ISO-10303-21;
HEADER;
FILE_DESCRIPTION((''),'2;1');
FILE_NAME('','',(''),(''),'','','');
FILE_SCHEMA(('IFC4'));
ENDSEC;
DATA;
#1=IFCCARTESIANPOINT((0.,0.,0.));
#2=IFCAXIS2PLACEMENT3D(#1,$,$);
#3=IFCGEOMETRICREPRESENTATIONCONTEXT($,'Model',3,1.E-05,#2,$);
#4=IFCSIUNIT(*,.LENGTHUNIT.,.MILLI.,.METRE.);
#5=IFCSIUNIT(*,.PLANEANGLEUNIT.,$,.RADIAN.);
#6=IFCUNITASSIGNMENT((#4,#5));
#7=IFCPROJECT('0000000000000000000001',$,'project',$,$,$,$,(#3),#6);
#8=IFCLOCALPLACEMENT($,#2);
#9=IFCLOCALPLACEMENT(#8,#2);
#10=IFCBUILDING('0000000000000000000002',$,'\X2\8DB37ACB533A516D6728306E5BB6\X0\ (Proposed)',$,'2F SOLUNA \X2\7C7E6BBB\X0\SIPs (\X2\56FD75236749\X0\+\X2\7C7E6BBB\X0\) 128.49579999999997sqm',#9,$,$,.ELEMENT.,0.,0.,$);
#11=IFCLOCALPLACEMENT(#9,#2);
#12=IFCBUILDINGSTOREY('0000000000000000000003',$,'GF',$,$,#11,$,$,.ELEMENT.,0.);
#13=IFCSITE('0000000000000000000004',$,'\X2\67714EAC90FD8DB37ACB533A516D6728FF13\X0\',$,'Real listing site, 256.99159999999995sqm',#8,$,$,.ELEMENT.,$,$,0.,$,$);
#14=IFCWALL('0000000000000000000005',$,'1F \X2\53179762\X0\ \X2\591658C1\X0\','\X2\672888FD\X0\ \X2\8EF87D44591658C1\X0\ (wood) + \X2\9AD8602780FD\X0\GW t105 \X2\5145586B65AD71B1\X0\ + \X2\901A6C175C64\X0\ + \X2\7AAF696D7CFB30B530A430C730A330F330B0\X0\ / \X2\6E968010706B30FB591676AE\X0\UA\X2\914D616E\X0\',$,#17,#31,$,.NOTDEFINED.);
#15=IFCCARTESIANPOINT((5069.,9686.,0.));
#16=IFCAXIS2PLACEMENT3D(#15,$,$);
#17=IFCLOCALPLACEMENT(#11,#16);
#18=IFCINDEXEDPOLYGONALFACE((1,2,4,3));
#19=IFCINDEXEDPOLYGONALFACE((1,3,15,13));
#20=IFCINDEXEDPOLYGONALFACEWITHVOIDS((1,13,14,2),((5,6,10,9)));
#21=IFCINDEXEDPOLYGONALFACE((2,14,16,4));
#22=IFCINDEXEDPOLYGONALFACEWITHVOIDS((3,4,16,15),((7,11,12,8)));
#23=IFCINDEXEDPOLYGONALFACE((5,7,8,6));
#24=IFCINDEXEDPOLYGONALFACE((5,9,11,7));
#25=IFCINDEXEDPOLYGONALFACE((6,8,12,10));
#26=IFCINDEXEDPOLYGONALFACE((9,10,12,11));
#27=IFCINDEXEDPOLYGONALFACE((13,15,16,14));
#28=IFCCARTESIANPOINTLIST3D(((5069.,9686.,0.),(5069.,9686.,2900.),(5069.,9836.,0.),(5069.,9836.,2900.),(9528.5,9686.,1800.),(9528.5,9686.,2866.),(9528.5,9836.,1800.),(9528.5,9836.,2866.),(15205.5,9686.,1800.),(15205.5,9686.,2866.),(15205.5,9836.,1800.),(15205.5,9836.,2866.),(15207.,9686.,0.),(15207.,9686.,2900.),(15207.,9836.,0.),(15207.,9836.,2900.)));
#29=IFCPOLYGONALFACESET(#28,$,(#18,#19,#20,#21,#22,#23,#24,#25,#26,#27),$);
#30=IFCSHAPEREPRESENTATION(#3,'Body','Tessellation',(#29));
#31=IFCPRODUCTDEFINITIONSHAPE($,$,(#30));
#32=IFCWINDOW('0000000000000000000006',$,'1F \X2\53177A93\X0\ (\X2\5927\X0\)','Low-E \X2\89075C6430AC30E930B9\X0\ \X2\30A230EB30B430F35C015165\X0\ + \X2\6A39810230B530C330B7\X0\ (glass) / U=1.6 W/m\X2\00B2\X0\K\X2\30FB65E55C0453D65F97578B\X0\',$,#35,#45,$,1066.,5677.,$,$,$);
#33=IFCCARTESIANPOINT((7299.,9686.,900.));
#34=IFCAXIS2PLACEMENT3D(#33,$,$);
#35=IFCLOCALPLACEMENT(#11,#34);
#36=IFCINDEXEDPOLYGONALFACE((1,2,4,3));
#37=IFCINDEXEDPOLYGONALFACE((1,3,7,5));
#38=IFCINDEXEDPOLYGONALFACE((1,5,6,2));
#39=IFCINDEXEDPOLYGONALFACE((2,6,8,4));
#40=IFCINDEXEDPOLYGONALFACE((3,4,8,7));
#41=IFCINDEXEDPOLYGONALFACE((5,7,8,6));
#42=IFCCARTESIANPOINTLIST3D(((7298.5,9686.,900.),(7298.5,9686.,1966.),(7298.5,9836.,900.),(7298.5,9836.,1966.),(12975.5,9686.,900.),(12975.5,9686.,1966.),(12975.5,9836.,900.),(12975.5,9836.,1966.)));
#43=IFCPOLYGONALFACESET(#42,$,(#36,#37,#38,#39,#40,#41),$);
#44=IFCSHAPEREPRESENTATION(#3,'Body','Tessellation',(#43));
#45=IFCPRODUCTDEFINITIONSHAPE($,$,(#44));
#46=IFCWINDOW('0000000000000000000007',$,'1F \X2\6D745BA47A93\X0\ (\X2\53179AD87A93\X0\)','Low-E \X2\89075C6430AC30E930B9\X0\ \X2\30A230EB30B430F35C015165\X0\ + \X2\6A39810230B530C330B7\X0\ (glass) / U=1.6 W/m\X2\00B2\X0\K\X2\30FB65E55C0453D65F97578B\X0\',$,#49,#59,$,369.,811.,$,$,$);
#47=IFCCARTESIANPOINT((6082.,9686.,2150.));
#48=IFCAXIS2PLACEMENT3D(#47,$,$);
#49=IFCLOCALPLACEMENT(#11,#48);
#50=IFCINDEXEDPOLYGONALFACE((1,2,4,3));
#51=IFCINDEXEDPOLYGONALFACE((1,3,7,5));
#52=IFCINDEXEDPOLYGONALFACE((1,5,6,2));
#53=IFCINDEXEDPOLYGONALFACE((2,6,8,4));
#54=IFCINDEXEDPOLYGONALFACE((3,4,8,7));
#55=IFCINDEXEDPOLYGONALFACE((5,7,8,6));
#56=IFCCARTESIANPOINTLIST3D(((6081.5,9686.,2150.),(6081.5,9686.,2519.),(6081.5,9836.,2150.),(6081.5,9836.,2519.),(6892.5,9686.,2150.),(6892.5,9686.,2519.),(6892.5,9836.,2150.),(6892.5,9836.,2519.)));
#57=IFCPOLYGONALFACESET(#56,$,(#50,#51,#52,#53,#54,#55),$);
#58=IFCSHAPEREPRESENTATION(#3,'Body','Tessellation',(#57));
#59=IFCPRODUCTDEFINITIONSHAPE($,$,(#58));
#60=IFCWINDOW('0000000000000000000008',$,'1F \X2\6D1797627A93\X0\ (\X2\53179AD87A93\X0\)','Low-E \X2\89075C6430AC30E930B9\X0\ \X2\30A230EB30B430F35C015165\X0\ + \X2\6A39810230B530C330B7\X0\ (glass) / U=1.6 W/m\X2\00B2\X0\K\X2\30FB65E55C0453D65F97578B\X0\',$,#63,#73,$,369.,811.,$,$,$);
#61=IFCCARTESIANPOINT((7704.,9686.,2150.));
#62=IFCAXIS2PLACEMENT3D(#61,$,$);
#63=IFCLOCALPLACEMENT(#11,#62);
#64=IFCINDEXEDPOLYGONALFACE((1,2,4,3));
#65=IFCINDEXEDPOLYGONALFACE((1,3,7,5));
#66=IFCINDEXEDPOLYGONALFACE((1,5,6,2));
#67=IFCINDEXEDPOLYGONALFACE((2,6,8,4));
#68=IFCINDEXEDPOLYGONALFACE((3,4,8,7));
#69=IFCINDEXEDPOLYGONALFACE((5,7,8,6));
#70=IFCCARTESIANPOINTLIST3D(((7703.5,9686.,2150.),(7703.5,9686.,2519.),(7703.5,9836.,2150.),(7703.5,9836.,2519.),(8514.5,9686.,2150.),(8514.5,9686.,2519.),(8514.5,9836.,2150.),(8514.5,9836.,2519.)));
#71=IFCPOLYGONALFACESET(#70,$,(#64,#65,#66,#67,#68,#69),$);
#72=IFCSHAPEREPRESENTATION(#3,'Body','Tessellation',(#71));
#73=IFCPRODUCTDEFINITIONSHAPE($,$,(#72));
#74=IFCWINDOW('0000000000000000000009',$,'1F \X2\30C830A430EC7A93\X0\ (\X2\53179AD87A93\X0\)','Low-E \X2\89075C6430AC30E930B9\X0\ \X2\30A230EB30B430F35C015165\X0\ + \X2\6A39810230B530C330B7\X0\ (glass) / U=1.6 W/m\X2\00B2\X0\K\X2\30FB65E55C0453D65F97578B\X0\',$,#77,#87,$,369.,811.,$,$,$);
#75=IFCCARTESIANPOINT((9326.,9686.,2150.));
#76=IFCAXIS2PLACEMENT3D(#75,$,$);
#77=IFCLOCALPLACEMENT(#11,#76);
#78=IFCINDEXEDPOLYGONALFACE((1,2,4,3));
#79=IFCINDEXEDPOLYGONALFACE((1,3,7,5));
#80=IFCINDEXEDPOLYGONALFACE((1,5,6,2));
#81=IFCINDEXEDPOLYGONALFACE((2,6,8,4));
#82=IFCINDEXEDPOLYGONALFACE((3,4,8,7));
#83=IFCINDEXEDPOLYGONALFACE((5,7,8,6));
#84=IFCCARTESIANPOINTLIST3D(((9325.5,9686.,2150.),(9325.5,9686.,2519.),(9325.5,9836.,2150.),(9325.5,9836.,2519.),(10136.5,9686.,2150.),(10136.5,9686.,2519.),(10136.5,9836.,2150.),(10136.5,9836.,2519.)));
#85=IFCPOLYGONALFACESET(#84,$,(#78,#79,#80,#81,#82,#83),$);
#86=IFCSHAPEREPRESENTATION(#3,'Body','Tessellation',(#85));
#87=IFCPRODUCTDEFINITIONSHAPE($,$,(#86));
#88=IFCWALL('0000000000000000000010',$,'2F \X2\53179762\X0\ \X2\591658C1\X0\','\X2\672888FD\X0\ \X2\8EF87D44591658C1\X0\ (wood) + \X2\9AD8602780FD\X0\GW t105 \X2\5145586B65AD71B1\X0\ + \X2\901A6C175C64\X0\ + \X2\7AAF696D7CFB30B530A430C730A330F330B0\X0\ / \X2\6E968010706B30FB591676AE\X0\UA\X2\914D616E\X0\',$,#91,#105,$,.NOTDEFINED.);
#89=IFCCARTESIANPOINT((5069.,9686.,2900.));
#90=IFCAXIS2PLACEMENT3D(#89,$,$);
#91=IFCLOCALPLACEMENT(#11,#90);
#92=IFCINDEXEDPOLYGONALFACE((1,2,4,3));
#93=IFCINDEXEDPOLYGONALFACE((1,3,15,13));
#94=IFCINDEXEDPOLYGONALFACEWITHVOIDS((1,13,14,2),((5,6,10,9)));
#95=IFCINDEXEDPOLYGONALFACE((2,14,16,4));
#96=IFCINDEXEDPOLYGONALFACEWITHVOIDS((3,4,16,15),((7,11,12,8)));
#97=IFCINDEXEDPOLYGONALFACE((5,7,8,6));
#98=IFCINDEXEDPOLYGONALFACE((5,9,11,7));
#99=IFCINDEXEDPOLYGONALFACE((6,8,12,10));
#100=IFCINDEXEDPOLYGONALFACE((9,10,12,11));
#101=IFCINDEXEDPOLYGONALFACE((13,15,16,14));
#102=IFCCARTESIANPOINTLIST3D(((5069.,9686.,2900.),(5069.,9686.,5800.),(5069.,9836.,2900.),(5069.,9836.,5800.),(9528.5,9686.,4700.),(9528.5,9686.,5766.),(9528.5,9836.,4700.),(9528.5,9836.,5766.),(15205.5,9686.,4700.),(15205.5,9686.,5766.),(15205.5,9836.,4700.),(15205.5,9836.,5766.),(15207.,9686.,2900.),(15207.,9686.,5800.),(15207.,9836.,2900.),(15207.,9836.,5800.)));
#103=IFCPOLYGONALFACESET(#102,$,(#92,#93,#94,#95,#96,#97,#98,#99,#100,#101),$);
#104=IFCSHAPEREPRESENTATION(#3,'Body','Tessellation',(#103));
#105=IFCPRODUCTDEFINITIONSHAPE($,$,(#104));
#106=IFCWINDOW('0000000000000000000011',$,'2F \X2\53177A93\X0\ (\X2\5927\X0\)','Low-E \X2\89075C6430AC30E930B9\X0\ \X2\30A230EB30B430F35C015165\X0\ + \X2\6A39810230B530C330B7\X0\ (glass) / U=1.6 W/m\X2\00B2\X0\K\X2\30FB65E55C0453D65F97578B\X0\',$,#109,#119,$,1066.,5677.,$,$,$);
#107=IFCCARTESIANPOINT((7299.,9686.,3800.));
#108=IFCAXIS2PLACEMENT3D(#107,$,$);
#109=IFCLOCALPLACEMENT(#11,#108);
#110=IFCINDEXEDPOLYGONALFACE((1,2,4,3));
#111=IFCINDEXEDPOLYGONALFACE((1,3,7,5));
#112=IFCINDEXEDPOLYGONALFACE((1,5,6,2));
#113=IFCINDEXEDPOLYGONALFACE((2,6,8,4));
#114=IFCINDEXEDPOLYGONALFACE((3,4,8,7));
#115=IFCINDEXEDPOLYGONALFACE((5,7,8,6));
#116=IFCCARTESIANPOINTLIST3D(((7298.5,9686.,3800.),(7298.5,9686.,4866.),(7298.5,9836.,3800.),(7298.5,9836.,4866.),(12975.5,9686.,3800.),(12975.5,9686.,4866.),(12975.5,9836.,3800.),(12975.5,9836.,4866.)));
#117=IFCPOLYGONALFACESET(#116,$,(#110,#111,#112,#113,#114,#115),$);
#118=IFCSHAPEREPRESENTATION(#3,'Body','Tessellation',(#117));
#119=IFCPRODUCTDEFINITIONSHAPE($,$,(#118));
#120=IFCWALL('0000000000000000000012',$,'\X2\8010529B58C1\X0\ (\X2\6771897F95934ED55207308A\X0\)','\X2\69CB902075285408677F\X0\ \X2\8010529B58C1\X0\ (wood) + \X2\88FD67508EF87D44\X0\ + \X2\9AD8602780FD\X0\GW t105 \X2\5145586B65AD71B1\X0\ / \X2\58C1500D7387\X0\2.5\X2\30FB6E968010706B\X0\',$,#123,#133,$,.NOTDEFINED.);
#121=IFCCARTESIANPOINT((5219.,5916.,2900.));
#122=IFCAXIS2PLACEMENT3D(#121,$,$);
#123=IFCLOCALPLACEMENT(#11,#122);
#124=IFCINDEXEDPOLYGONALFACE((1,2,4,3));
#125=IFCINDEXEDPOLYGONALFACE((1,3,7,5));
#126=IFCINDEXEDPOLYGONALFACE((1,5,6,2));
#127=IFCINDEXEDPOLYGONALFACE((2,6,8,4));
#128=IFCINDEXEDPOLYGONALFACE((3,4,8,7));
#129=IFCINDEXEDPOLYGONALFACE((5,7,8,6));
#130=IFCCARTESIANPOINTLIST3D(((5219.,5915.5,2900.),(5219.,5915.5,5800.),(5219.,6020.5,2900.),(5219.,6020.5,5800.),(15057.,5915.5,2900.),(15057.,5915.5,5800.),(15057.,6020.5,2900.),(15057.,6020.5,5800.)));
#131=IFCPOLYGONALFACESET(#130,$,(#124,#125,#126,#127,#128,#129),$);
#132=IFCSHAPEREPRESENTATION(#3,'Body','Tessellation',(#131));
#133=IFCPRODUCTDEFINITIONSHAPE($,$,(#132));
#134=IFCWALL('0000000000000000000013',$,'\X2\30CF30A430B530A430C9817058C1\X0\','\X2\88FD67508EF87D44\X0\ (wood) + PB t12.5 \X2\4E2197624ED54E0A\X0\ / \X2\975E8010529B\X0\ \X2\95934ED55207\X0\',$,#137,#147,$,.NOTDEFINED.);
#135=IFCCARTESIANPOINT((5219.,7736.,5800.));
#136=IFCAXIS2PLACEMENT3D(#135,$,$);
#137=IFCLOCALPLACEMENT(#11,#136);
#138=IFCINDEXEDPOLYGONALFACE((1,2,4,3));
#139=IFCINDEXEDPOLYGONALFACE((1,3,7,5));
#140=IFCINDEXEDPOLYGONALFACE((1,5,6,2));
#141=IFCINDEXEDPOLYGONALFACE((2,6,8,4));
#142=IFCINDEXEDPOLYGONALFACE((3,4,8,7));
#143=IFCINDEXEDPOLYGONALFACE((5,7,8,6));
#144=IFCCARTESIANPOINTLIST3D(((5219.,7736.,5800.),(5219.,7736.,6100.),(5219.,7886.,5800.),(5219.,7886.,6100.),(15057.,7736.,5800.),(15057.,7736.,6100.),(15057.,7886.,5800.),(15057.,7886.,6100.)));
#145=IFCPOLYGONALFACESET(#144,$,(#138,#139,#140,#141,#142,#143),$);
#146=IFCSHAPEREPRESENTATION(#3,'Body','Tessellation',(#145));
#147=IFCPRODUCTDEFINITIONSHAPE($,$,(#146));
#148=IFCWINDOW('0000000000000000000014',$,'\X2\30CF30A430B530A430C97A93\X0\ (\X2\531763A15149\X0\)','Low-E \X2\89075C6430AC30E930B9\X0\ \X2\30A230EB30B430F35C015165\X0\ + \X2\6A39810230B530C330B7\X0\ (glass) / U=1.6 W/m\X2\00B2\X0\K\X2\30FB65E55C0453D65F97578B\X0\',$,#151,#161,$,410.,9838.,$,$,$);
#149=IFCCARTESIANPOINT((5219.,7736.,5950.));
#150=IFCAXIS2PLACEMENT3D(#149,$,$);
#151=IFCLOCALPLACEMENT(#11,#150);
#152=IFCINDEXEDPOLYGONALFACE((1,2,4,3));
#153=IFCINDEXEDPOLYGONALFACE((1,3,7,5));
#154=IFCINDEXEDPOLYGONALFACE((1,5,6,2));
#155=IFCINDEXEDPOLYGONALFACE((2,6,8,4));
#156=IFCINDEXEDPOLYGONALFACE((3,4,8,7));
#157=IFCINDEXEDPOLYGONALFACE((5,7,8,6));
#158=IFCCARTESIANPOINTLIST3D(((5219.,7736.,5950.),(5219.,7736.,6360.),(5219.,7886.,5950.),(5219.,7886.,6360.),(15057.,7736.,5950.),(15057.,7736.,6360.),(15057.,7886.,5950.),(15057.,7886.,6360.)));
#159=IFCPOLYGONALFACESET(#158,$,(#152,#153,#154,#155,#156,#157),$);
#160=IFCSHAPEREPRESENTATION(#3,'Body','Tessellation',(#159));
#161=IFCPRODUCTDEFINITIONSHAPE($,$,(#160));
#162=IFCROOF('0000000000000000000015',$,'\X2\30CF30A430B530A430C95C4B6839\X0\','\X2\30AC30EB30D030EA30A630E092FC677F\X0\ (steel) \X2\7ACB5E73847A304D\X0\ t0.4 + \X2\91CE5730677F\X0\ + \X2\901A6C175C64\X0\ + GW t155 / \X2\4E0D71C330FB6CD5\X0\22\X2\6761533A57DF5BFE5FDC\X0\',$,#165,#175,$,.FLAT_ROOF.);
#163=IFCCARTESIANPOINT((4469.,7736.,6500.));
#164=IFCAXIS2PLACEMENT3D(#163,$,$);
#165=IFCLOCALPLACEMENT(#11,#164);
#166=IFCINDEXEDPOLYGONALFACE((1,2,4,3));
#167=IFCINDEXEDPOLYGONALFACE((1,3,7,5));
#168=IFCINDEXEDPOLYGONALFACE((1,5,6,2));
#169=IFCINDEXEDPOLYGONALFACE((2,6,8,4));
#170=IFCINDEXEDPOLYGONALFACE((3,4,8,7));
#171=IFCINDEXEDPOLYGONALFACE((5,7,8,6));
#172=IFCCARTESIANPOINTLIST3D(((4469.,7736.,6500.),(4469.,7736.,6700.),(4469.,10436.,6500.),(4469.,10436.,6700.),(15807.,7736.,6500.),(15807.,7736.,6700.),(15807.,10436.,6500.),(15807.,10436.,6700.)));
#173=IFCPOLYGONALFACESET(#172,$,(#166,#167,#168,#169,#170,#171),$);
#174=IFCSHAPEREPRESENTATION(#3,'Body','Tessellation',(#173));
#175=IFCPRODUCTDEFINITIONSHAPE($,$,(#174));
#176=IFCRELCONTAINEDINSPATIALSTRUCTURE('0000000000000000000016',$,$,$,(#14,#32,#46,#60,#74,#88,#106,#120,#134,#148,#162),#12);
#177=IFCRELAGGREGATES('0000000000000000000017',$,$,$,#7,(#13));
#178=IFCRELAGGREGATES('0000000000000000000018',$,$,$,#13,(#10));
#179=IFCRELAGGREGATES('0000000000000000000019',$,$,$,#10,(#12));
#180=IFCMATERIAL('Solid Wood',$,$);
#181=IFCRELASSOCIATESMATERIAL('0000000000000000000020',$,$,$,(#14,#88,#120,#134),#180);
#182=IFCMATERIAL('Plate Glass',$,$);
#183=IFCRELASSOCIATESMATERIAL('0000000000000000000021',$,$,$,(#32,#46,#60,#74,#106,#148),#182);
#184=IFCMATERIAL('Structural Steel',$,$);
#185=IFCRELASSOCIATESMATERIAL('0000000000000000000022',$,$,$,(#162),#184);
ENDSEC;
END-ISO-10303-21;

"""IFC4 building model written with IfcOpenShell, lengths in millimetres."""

from ifc_helpers import new_model, si_unit, frame, frame_2d, origin, place, context, project, spatial, rectangle, extrude, material, element, fill, save


model = new_model("IFC4")

# Units and contexts
model_context = context("Model", 3, precision=1e-05, world=origin())
ifc_project = project(units=[si_unit("LENGTHUNIT", "METRE", prefix="MILLI"), si_unit("PLANEANGLEUNIT", "RADIAN")], contexts=[model_context])

# Site, building, storey
site_placement = place(None, origin())
site = spatial("IfcSite", under=ifc_project, at=site_placement, Name="東京都足立区六木３", ObjectType="Real listing site, 256.99159999999995sqm", CompositionType="ELEMENT", RefElevation=0.0)
building_placement = place(site_placement, origin())
building = spatial("IfcBuilding", under=site, at=building_placement, Name="足立区六木の家 (Proposed)", ObjectType="2F SOLUNA 籾殻SIPs (国産杉+籾殻) 128.49579999999997sqm", CompositionType="ELEMENT", ElevationOfRefHeight=0.0, ElevationOfTerrain=0.0)
storey_placement = place(building_placement, origin())
storey = spatial("IfcBuildingStorey", under=building, at=storey_placement, Name="GF", CompositionType="ELEMENT", Elevation=0.0)

# Wall, openings, windows
ifc_material_1 = material(Name="Solid Wood")
wall_1_placement = place(storey_placement, frame((5069.0, 9686.0, 0.0)))
wall_1 = element("IfcWall", 1, at=wall_1_placement, inside=storey, material=ifc_material_1, Name="1F 北面 外壁", Description="木製 軸組外壁 (wood) + 高性能GW t105 充填断熱 + 通気層 + 窯業系サイディング / 準耐火・外皮UA配慮", PredefinedType="NOTDEFINED", context=model_context, shape_type="SweptSolid", body=[
    extrude(rectangle(XDim=10138.0, YDim=150.0, at=frame_2d((5069.0, 75.0))), frame((5069.0, 9686.0, 0.0)), (0.0, 0.0, 1.0), 2900.0),
])
opening_1_placement = place(storey_placement, frame((7299.0, 9686.0, 900.0)))
opening_1 = element("IfcOpeningElement", 2, at=opening_1_placement, cuts=wall_1, PredefinedType="NOTDEFINED", context=model_context, shape_type="SweptSolid", body=[
    extrude(rectangle(XDim=5677.0, YDim=150.0, at=frame_2d((2838.0, 75.0))), frame((7299.0, 9686.0, 900.0)), (0.0, 0.0, 1.0), 1066.0),
])
opening_2_placement = place(storey_placement, frame((6082.0, 9686.0, 2150.0)))
opening_2 = element("IfcOpeningElement", 3, at=opening_2_placement, cuts=wall_1, PredefinedType="NOTDEFINED", context=model_context, shape_type="SweptSolid", body=[
    extrude(rectangle(XDim=811.0, YDim=150.0, at=frame_2d((405.0, 75.0))), frame((6082.0, 9686.0, 2150.0)), (0.0, 0.0, 1.0), 369.0),
])
opening_3_placement = place(storey_placement, frame((7704.0, 9686.0, 2150.0)))
opening_3 = element("IfcOpeningElement", 4, at=opening_3_placement, cuts=wall_1, PredefinedType="NOTDEFINED", context=model_context, shape_type="SweptSolid", body=[
    extrude(rectangle(XDim=811.0, YDim=150.0, at=frame_2d((405.0, 75.0))), frame((7704.0, 9686.0, 2150.0)), (0.0, 0.0, 1.0), 369.0),
])
opening_4_placement = place(storey_placement, frame((9326.0, 9686.0, 2150.0)))
opening_4 = element("IfcOpeningElement", 5, at=opening_4_placement, cuts=wall_1, PredefinedType="NOTDEFINED", context=model_context, shape_type="SweptSolid", body=[
    extrude(rectangle(XDim=811.0, YDim=150.0, at=frame_2d((405.0, 75.0))), frame((9326.0, 9686.0, 2150.0)), (0.0, 0.0, 1.0), 369.0),
])
ifc_material_2 = material(Name="Plate Glass")
window_1_placement = place(storey_placement, frame((7299.0, 9686.0, 900.0)))
window_1 = element("IfcWindow", 6, at=window_1_placement, inside=storey, material=ifc_material_2, Name="1F 北窓 (大)", Description="Low-E 複層ガラス アルゴン封入 + 樹脂サッシ (glass) / U=1.6 W/m²K・日射取得型", OverallHeight=1066.0, OverallWidth=5677.0, context=model_context, shape_type="SweptSolid", body=[
    extrude(rectangle(XDim=5677.0, YDim=150.0, at=frame_2d((2838.0, 75.0))), frame((7299.0, 9686.0, 900.0)), (0.0, 0.0, 1.0), 1066.0),
])
fill(opening_1, window_1)
window_2_placement = place(storey_placement, frame((6082.0, 9686.0, 2150.0)))
window_2 = element("IfcWindow", 7, at=window_2_placement, inside=storey, material=ifc_material_2, Name="1F 浴室窓 (北高窓)", Description="Low-E 複層ガラス アルゴン封入 + 樹脂サッシ (glass) / U=1.6 W/m²K・日射取得型", OverallHeight=369.0, OverallWidth=811.0, context=model_context, shape_type="SweptSolid", body=[
    extrude(rectangle(XDim=811.0, YDim=150.0, at=frame_2d((405.0, 75.0))), frame((6082.0, 9686.0, 2150.0)), (0.0, 0.0, 1.0), 369.0),
])
fill(opening_2, window_2)
window_3_placement = place(storey_placement, frame((7704.0, 9686.0, 2150.0)))
window_3 = element("IfcWindow", 8, at=window_3_placement, inside=storey, material=ifc_material_2, Name="1F 洗面窓 (北高窓)", Description="Low-E 複層ガラス アルゴン封入 + 樹脂サッシ (glass) / U=1.6 W/m²K・日射取得型", OverallHeight=369.0, OverallWidth=811.0, context=model_context, shape_type="SweptSolid", body=[
    extrude(rectangle(XDim=811.0, YDim=150.0, at=frame_2d((405.0, 75.0))), frame((7704.0, 9686.0, 2150.0)), (0.0, 0.0, 1.0), 369.0),
])
fill(opening_3, window_3)
window_4_placement = place(storey_placement, frame((9326.0, 9686.0, 2150.0)))
window_4 = element("IfcWindow", 9, at=window_4_placement, inside=storey, material=ifc_material_2, Name="1F トイレ窓 (北高窓)", Description="Low-E 複層ガラス アルゴン封入 + 樹脂サッシ (glass) / U=1.6 W/m²K・日射取得型", OverallHeight=369.0, OverallWidth=811.0, context=model_context, shape_type="SweptSolid", body=[
    extrude(rectangle(XDim=811.0, YDim=150.0, at=frame_2d((405.0, 75.0))), frame((9326.0, 9686.0, 2150.0)), (0.0, 0.0, 1.0), 369.0),
])
fill(opening_4, window_4)

# Wall, opening, window
wall_2_placement = place(storey_placement, frame((5069.0, 9686.0, 2900.0)))
wall_2 = element("IfcWall", 10, at=wall_2_placement, inside=storey, material=ifc_material_1, Name="2F 北面 外壁", Description="木製 軸組外壁 (wood) + 高性能GW t105 充填断熱 + 通気層 + 窯業系サイディング / 準耐火・外皮UA配慮", PredefinedType="NOTDEFINED", context=model_context, shape_type="SweptSolid", body=[
    extrude(rectangle(XDim=10138.0, YDim=150.0, at=frame_2d((5069.0, 75.0))), frame((5069.0, 9686.0, 2900.0)), (0.0, 0.0, 1.0), 2900.0),
])
opening_5_placement = place(storey_placement, frame((7299.0, 9686.0, 3800.0)))
opening_5 = element("IfcOpeningElement", 11, at=opening_5_placement, cuts=wall_2, PredefinedType="NOTDEFINED", context=model_context, shape_type="SweptSolid", body=[
    extrude(rectangle(XDim=5677.0, YDim=150.0, at=frame_2d((2838.0, 75.0))), frame((7299.0, 9686.0, 3800.0)), (0.0, 0.0, 1.0), 1066.0),
])
window_5_placement = place(storey_placement, frame((7299.0, 9686.0, 3800.0)))
window_5 = element("IfcWindow", 12, at=window_5_placement, inside=storey, material=ifc_material_2, Name="2F 北窓 (大)", Description="Low-E 複層ガラス アルゴン封入 + 樹脂サッシ (glass) / U=1.6 W/m²K・日射取得型", OverallHeight=1066.0, OverallWidth=5677.0, context=model_context, shape_type="SweptSolid", body=[
    extrude(rectangle(XDim=5677.0, YDim=150.0, at=frame_2d((2838.0, 75.0))), frame((7299.0, 9686.0, 3800.0)), (0.0, 0.0, 1.0), 1066.0),
])
fill(opening_5, window_5)

# Wall
wall_3_placement = place(storey_placement, frame((5219.0, 5916.0, 2900.0)))
element("IfcWall", 13, at=wall_3_placement, inside=storey, material=ifc_material_1, Name="耐力壁 (東西間仕切り)", Description="構造用合板 耐力壁 (wood) + 製材軸組 + 高性能GW t105 充填断熱 / 壁倍率2.5・準耐火", PredefinedType="NOTDEFINED", context=model_context, shape_type="SweptSolid", body=[
    extrude(rectangle(XDim=9838.0, YDim=105.0, at=frame_2d((4919.0, 52.0))), frame((5219.0, 5916.0, 2900.0)), (0.0, 0.0, 1.0), 2900.0),
])

# Wall, opening, window
wall_4_placement = place(storey_placement, frame((5219.0, 7736.0, 5800.0)))
wall_4 = element("IfcWall", 14, at=wall_4_placement, inside=storey, material=ifc_material_1, Name="ハイサイド腰壁", Description="製材軸組 (wood) + PB t12.5 両面仕上 / 非耐力 間仕切", PredefinedType="NOTDEFINED", context=model_context, shape_type="SweptSolid", body=[
    extrude(rectangle(XDim=9838.0, YDim=150.0, at=frame_2d((4919.0, 75.0))), frame((5219.0, 7736.0, 5800.0)), (0.0, 0.0, 1.0), 700.0),
])
opening_6_placement = place(storey_placement, frame((5219.0, 7736.0, 5950.0)))
opening_6 = element("IfcOpeningElement", 15, at=opening_6_placement, cuts=wall_4, PredefinedType="NOTDEFINED", context=model_context, shape_type="SweptSolid", body=[
    extrude(rectangle(XDim=9838.0, YDim=150.0, at=frame_2d((4919.0, 75.0))), frame((5219.0, 7736.0, 5950.0)), (0.0, 0.0, 1.0), 410.0),
])
window_6_placement = place(storey_placement, frame((5219.0, 7736.0, 5950.0)))
window_6 = element("IfcWindow", 16, at=window_6_placement, inside=storey, material=ifc_material_2, Name="ハイサイド窓 (北採光)", Description="Low-E 複層ガラス アルゴン封入 + 樹脂サッシ (glass) / U=1.6 W/m²K・日射取得型", OverallHeight=410.0, OverallWidth=9838.0, context=model_context, shape_type="SweptSolid", body=[
    extrude(rectangle(XDim=9838.0, YDim=150.0, at=frame_2d((4919.0, 75.0))), frame((5219.0, 7736.0, 5950.0)), (0.0, 0.0, 1.0), 410.0),
])
fill(opening_6, window_6)

# Roof
ifc_material_3 = material(Name="Structural Steel")
roof_placement = place(storey_placement, frame((4469.0, 7736.0, 6500.0)))
element("IfcRoof", 17, at=roof_placement, inside=storey, material=ifc_material_3, Name="ハイサイド屋根", Description="ガルバリウム鋼板 (steel) 立平葺き t0.4 + 野地板 + 通気層 + GW t155 / 不燃・法22条区域対応", PredefinedType="FLAT_ROOF", context=model_context, shape_type="SweptSolid", body=[
    extrude(rectangle(XDim=11338.0, YDim=2700.0, at=frame_2d((5669.0, 1350.0))), frame((4469.0, 7736.0, 6500.0)), (0.0, 0.0, 1.0), 200.0),
])

save(model, "model.ifc")
